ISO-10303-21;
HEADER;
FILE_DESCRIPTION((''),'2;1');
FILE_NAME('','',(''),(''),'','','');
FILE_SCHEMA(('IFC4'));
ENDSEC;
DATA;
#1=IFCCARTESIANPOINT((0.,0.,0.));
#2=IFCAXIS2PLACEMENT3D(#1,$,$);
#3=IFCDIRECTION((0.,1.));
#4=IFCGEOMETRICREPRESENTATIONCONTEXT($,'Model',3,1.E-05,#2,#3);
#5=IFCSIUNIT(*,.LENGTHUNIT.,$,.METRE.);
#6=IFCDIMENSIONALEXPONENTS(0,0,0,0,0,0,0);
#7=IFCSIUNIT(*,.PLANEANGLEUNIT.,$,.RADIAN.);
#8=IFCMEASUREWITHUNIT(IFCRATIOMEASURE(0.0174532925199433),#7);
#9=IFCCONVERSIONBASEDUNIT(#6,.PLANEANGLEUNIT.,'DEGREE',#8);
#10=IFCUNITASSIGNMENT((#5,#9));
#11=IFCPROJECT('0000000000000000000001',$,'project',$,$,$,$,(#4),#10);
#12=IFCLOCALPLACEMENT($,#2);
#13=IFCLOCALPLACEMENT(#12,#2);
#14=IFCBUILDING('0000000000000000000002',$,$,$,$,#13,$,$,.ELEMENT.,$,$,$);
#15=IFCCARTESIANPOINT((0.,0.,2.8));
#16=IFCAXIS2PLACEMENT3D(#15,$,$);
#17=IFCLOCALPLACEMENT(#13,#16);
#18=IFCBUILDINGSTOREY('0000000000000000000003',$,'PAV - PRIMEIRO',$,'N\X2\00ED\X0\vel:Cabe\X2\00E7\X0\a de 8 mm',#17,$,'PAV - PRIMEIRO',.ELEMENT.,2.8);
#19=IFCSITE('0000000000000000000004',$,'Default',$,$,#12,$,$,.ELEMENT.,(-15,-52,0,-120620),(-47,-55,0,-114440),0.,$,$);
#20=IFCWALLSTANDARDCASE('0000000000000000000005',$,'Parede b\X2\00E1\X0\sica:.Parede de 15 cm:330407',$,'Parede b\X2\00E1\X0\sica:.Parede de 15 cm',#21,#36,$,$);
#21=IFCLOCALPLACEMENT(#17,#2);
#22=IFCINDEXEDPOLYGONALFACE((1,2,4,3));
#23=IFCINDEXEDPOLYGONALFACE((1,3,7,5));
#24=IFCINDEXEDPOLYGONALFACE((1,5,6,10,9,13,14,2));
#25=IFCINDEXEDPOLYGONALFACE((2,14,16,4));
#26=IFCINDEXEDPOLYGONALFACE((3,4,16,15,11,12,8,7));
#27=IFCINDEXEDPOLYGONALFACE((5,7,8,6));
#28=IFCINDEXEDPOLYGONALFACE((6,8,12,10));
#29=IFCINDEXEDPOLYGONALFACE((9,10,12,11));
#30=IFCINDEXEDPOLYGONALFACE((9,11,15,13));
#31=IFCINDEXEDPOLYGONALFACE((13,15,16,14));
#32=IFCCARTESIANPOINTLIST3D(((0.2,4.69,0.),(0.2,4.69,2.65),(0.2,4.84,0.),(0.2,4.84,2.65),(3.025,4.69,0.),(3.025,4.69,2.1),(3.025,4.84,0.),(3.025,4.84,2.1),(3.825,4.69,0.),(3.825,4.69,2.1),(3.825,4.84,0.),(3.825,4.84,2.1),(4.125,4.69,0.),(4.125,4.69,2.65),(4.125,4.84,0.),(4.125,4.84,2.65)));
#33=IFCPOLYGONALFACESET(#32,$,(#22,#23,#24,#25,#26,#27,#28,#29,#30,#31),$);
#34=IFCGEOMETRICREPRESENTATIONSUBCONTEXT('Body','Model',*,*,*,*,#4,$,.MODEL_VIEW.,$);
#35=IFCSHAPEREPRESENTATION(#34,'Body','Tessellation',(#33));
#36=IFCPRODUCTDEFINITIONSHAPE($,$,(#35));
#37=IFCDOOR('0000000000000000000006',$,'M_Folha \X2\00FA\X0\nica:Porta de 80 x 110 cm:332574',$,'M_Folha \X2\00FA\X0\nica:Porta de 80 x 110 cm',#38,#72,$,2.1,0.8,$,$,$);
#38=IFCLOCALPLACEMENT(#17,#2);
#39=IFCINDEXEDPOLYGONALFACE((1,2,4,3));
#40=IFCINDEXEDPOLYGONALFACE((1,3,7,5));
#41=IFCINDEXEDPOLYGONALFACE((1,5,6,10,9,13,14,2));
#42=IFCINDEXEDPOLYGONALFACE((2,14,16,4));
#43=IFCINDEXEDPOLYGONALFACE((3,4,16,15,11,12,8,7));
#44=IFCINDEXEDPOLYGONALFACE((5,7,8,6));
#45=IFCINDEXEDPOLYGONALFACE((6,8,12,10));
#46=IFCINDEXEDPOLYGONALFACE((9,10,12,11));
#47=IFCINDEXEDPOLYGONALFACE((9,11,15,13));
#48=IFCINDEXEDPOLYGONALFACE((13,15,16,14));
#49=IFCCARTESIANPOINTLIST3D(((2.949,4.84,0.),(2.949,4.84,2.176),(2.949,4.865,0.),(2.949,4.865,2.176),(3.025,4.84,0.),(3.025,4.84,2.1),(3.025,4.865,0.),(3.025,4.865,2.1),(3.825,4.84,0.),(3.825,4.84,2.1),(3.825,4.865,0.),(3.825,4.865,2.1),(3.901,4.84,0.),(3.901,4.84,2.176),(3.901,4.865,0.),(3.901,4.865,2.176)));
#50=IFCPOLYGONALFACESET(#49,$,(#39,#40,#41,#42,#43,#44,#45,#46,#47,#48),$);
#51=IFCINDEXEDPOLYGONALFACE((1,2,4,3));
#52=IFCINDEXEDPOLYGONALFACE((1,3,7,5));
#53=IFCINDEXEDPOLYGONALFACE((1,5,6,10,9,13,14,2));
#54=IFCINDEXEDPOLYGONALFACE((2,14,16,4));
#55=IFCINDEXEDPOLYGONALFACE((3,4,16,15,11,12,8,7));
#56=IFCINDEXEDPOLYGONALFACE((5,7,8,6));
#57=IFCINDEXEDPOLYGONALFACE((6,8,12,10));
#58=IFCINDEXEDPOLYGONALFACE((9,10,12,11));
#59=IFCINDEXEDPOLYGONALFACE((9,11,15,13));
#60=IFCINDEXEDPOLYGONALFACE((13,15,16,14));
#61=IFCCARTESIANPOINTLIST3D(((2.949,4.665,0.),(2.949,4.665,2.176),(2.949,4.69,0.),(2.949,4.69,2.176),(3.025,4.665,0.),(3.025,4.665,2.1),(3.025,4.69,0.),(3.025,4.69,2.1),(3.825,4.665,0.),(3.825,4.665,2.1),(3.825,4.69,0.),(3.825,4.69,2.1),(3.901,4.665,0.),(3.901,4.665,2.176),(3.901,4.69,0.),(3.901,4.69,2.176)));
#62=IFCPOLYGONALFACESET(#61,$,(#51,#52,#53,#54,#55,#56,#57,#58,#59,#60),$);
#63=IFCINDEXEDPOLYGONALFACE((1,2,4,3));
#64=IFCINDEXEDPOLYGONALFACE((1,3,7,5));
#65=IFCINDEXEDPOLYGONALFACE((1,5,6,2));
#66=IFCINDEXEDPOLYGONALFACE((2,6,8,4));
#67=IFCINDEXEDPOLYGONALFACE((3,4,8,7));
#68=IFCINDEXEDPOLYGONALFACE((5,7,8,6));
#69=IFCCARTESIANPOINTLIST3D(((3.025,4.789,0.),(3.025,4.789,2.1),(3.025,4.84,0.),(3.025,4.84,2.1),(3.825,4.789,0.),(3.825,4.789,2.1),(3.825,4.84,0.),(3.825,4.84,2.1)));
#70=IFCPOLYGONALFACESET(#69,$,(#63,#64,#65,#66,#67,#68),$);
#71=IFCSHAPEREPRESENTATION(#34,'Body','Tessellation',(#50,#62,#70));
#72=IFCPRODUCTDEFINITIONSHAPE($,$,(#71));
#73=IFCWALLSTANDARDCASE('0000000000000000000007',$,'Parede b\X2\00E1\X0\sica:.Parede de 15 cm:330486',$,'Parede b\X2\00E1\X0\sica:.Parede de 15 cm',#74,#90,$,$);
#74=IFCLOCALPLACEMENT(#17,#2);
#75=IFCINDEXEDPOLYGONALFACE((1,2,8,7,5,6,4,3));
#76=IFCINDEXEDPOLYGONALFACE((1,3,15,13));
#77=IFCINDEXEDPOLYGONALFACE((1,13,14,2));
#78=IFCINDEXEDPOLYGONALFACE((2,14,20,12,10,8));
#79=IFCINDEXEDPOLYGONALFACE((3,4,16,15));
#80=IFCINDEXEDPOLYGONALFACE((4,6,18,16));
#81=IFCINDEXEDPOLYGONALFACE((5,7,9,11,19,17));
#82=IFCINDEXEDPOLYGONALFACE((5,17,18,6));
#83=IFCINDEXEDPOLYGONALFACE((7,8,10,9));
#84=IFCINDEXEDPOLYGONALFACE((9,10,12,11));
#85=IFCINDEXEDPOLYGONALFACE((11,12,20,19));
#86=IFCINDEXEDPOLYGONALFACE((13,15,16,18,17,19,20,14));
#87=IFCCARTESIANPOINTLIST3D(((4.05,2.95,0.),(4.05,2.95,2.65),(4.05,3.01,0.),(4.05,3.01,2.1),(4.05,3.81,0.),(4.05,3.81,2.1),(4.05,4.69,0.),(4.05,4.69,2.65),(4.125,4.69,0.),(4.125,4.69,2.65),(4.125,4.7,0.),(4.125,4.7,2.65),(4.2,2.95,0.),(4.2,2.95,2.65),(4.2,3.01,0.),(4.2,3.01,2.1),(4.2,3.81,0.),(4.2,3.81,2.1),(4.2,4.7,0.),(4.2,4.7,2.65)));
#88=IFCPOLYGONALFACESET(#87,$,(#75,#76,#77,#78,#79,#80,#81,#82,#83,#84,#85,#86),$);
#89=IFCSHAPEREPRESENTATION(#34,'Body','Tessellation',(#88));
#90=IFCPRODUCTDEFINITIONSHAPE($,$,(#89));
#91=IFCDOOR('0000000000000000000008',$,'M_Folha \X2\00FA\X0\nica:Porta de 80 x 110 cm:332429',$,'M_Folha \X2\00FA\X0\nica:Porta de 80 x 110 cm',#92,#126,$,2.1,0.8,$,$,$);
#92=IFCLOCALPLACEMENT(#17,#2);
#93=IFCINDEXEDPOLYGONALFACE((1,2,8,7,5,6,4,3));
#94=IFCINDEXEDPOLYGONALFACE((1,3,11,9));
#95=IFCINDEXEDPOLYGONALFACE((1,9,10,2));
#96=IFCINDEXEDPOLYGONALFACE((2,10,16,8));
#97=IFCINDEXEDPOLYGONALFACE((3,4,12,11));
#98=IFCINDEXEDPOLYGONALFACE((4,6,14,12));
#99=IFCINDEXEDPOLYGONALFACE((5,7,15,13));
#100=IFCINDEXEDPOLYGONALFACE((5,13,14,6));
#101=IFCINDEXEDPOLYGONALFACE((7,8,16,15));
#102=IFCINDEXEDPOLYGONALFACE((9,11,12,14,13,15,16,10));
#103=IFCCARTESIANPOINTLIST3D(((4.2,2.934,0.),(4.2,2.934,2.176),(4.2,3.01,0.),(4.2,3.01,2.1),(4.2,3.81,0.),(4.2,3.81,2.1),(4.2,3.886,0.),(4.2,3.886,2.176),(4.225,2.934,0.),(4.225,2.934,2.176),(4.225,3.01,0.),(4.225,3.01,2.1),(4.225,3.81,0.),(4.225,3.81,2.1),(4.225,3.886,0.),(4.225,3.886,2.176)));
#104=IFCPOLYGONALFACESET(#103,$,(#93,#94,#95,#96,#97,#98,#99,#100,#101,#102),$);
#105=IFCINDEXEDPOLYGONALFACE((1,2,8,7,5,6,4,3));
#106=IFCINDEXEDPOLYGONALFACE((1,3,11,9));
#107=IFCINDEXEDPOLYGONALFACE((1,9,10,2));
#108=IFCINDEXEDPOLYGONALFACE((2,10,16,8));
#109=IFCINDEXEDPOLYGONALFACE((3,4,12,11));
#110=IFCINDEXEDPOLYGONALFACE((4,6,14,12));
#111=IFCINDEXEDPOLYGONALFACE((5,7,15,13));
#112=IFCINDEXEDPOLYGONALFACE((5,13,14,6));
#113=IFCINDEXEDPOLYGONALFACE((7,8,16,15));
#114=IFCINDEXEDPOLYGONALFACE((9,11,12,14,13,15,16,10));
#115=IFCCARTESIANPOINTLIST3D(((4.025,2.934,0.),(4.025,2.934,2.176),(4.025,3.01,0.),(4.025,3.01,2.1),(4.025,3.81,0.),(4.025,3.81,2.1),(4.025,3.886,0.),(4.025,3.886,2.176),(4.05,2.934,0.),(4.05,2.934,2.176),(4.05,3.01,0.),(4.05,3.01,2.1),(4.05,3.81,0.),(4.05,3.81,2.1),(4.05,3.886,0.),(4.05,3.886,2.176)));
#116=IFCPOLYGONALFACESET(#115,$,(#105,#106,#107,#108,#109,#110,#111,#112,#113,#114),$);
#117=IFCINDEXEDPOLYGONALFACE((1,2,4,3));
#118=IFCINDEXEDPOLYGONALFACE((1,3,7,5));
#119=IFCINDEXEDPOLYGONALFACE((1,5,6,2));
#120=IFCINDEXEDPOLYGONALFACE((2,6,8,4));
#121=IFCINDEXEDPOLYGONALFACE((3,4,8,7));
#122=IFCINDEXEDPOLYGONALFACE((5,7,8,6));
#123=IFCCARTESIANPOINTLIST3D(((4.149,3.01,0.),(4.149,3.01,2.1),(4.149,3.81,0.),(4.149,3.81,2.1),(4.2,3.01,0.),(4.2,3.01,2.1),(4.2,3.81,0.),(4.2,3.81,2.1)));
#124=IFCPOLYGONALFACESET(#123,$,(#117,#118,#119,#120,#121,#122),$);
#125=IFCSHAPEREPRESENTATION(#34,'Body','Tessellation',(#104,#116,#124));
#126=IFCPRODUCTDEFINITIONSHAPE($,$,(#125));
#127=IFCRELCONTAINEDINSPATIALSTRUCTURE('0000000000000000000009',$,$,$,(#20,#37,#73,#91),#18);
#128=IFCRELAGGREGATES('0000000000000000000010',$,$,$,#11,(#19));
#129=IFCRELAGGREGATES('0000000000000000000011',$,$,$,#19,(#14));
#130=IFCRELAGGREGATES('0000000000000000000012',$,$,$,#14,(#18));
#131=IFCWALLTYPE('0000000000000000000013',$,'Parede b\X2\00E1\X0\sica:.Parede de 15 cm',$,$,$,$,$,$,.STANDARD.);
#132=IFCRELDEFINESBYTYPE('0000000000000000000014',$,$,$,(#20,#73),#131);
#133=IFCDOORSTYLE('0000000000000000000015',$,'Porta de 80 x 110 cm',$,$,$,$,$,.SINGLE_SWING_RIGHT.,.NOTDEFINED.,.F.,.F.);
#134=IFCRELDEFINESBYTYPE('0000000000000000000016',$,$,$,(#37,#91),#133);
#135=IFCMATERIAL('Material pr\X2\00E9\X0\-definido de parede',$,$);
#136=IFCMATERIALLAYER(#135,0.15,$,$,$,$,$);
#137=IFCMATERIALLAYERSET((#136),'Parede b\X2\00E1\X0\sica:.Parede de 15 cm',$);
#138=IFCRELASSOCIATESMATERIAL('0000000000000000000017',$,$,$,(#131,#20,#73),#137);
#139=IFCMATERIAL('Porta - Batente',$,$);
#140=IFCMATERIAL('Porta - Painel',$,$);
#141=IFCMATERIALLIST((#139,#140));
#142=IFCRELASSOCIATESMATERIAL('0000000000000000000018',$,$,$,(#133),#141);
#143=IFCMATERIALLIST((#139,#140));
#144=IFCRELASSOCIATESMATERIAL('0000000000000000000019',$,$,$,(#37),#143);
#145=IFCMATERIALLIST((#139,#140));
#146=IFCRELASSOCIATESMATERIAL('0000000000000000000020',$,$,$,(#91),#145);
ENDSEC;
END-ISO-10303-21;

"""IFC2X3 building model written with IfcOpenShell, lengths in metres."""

from ifc_helpers import new_model, entity, si_unit, converted_unit, direction, frame, frame_2d, origin, place, context, subcontext, project, spatial, polyline, rectangle, outline, extrude, clip, bounded_halfspace, source, transform, mapped, material, material_list, layer, layer_set, layer_usage, type_object, type_shapes, element, fill, save


model = new_model("IFC2X3")

# Units and contexts
model_context = context("Model", 3, precision=1e-05, world=origin(), true_north=direction((0.0, 1.0)))
body_context = subcontext(model_context, "Body", "Model", "MODEL_VIEW")
ifc_project = project(units=[si_unit("LENGTHUNIT", "METRE"), converted_unit("PLANEANGLEUNIT", "DEGREE", entity("IfcRatioMeasure", 0.0174532925199433), si_unit("PLANEANGLEUNIT", "RADIAN"), dimensions=[0, 0, 0, 0, 0, 0, 0])], contexts=[model_context])

# Site, building, storey
site_placement = place(None, origin())
site = spatial("IfcSite", under=ifc_project, at=site_placement, Name="Default", CompositionType="ELEMENT", RefLatitude=(-15, -52, 0, -120620), RefLongitude=(-47, -55, 0, -114440), RefElevation=0.0)
building_placement = place(site_placement, origin())
building = spatial("IfcBuilding", under=site, at=building_placement, CompositionType="ELEMENT")
storey_placement = place(building_placement, frame((0.0, 0.0, 2.8)))
storey = spatial("IfcBuildingStorey", under=building, at=storey_placement, Name="PAV - PRIMEIRO", ObjectType="Nível:Cabeça de 8 mm", LongName="PAV - PRIMEIRO", CompositionType="ELEMENT", Elevation=2.8)

# Shared definitions
ifc_material_1 = material(Name="Material pré-definido de parede")

# Shared definitions
ifc_material_2 = material(Name="Porta - Batente")
ifc_material_3 = material(Name="Porta - Painel")

# Walls, openings, doors
ifc_layer_1 = layer(ifc_material_1, 0.15)
ifc_layer_set_1 = layer_set([ifc_layer_1], Name="Parede básica:.Parede de 15 cm")
ifc_layer_usage_1 = layer_usage(ifc_layer_set_1, "AXIS2", "NEGATIVE", 0.075)
wall_type_1 = type_object("IfcWallType", Name="Parede básica:.Parede de 15 cm", PredefinedType="STANDARD", material=ifc_layer_set_1)
wall_1_placement = place(storey_placement, frame((0.2, 4.765, 0.0)))
wall_1 = element("IfcWallStandardCase", 1, at=wall_1_placement, inside=storey, type_object=wall_type_1, material=ifc_layer_usage_1, Name="Parede básica:.Parede de 15 cm:330407", ObjectType="Parede básica:.Parede de 15 cm", context=body_context, shape_type="Clipping", body=[
    clip(extrude(rectangle(XDim=3.925, YDim=0.15, at=frame_2d((1.9625, 0.0), x_axis=(-1.0, 0.0))), origin(), (0.0, 0.0, 1.0), 2.65), bounded_halfspace(frame((0.0, -0.075, 2.65), z_axis=(0.0, 0.0, -1.0), x_axis=(0.0, -1.0, 0.0)), True, frame((0.0, -0.075, 2.65)), polyline([(0.0, 0.0), (3.85, 0.0), (3.925, 0.0), (3.925, 0.01), (3.925, 0.15), (0.0, 0.15), (0.0, 0.0)]))),
])
opening_1_placement = place(wall_1_placement, frame((2.825, -0.075, 0.0)))
opening_1 = element("IfcOpeningElement", 2, at=opening_1_placement, cuts=wall_1, ObjectType="Opening", context=body_context, shape_type="SweptSolid", body=[
    extrude(rectangle(XDim=0.8, YDim=2.1, at=frame_2d((1.05, 0.4), x_axis=(0.0, 1.0))), frame((0.0, 0.0, 0.0), z_axis=(0.0, 1.0, 0.0), x_axis=(0.0, 0.0, 1.0)), (0.0, 0.0, 1.0), 0.15),
])
ifc_material_list_1 = material_list([ifc_material_2, ifc_material_3])
ifc_material_list_2 = material_list([ifc_material_2, ifc_material_3])
door_style_1 = type_object("IfcDoorStyle", Name="Porta de 80 x 110 cm", ConstructionType="NOTDEFINED", OperationType="SINGLE_SWING_RIGHT", ParameterTakesPrecedence=False, Sizeable=False, material=ifc_material_list_2)
shared_shape_1 = source(origin(), body_context, "Body", "SweptSolid", [
    extrude(outline(polyline([(-0.476, -1.107), (0.476, -1.107), (0.476, 1.069), (0.4, 1.069), (0.4, -1.031), (-0.4, -1.031), (-0.4, 1.069), (-0.476, 1.069), (-0.476, -1.107)])), frame((0.4, 0.15, 1.069), z_axis=(0.0, 1.0, 0.0), x_axis=(1.0, 0.0, 0.0)), (0.0, 0.0, 1.0), 0.025),
    extrude(outline(polyline([(-1.107, -0.476), (1.069, -0.476), (1.069, -0.4), (-1.031, -0.4), (-1.031, 0.4), (1.069, 0.4), (1.069, 0.476), (-1.107, 0.476), (-1.107, -0.476)])), frame((0.4, -0.025, 1.069), z_axis=(0.0, 1.0, 0.0), x_axis=(0.0, 0.0, -1.0)), (0.0, 0.0, 1.0), 0.025),
    extrude(rectangle(XDim=0.051, YDim=0.8, at=frame_2d((0.0, 0.0), x_axis=(1.0, 0.0))), frame((0.4, 0.1245, 0.0), z_axis=(0.0, 0.0, 1.0), x_axis=(0.0, 1.0, 0.0)), (0.0, 0.0, 1.0), 2.1),
])
type_shapes(door_style_1, [shared_shape_1])
door_1_placement = place(opening_1_placement, origin())
door_1 = element("IfcDoor", 3, at=door_1_placement, inside=storey, type_object=door_style_1, material=ifc_material_list_1, Name="M_Folha única:Porta de 80 x 110 cm:332574", ObjectType="M_Folha única:Porta de 80 x 110 cm", OverallHeight=2.1, OverallWidth=0.8, context=body_context, shape_type="MappedRepresentation", body=[
    mapped(shared_shape_1, transform((0.0, 0.0, 0.0), scale=1.0)),
])
fill(opening_1, door_1)
ifc_layer_usage_2 = layer_usage(ifc_layer_set_1, "AXIS2", "NEGATIVE", 0.075)
wall_2_placement = place(storey_placement, frame((4.125, 2.95, 0.0), z_axis=(0.0, 0.0, 1.0), x_axis=(0.0, 1.0, 0.0)))
wall_2 = element("IfcWallStandardCase", 4, at=wall_2_placement, inside=storey, type_object=wall_type_1, material=ifc_layer_usage_2, Name="Parede básica:.Parede de 15 cm:330486", ObjectType="Parede básica:.Parede de 15 cm", context=body_context, shape_type="Clipping", body=[
    clip(extrude(outline(polyline([(0.0, -0.075), (1.75, -0.075), (1.75, 0.0), (1.74, 0.0), (1.74, 0.075), (0.0, 0.075), (0.0, -0.075)])), origin(), (0.0, 0.0, 1.0), 2.65), bounded_halfspace(frame((0.0, -0.075, 2.65), z_axis=(0.0, 0.0, -1.0), x_axis=(-1.0, 0.0, 0.0)), True, frame((0.0, -0.075, 2.65)), polyline([(0.0, 0.0), (1.75, 0.0), (1.75, 0.075), (1.74, 0.075), (1.74, 0.15), (0.0, 0.15), (0.0, 0.0)]))),
])
opening_2_placement = place(wall_2_placement, frame((0.86, 0.075, 0.0)))
opening_2 = element("IfcOpeningElement", 5, at=opening_2_placement, cuts=wall_2, ObjectType="Opening", context=body_context, shape_type="SweptSolid", body=[
    extrude(rectangle(XDim=0.8, YDim=2.1, at=frame_2d((1.05, 0.4), x_axis=(0.0, 1.0))), frame((0.0, 0.0, 0.0), z_axis=(0.0, -1.0, 0.0), x_axis=(0.0, 0.0, 1.0)), (0.0, 0.0, 1.0), 0.15),
])
ifc_material_list_3 = material_list([ifc_material_2, ifc_material_3])
door_2_placement = place(opening_2_placement, frame((0.0, 0.0, 0.0), z_axis=(0.0, 0.0, 1.0), x_axis=(-1.0, 0.0, 0.0)))
door_2 = element("IfcDoor", 6, at=door_2_placement, inside=storey, type_object=door_style_1, material=ifc_material_list_3, Name="M_Folha única:Porta de 80 x 110 cm:332429", ObjectType="M_Folha única:Porta de 80 x 110 cm", OverallHeight=2.1, OverallWidth=0.8, context=body_context, shape_type="MappedRepresentation", body=[
    mapped(shared_shape_1, transform((0.0, 0.0, 0.0), scale=1.0)),
])
fill(opening_2, door_2)

save(model, "model.ifc")
